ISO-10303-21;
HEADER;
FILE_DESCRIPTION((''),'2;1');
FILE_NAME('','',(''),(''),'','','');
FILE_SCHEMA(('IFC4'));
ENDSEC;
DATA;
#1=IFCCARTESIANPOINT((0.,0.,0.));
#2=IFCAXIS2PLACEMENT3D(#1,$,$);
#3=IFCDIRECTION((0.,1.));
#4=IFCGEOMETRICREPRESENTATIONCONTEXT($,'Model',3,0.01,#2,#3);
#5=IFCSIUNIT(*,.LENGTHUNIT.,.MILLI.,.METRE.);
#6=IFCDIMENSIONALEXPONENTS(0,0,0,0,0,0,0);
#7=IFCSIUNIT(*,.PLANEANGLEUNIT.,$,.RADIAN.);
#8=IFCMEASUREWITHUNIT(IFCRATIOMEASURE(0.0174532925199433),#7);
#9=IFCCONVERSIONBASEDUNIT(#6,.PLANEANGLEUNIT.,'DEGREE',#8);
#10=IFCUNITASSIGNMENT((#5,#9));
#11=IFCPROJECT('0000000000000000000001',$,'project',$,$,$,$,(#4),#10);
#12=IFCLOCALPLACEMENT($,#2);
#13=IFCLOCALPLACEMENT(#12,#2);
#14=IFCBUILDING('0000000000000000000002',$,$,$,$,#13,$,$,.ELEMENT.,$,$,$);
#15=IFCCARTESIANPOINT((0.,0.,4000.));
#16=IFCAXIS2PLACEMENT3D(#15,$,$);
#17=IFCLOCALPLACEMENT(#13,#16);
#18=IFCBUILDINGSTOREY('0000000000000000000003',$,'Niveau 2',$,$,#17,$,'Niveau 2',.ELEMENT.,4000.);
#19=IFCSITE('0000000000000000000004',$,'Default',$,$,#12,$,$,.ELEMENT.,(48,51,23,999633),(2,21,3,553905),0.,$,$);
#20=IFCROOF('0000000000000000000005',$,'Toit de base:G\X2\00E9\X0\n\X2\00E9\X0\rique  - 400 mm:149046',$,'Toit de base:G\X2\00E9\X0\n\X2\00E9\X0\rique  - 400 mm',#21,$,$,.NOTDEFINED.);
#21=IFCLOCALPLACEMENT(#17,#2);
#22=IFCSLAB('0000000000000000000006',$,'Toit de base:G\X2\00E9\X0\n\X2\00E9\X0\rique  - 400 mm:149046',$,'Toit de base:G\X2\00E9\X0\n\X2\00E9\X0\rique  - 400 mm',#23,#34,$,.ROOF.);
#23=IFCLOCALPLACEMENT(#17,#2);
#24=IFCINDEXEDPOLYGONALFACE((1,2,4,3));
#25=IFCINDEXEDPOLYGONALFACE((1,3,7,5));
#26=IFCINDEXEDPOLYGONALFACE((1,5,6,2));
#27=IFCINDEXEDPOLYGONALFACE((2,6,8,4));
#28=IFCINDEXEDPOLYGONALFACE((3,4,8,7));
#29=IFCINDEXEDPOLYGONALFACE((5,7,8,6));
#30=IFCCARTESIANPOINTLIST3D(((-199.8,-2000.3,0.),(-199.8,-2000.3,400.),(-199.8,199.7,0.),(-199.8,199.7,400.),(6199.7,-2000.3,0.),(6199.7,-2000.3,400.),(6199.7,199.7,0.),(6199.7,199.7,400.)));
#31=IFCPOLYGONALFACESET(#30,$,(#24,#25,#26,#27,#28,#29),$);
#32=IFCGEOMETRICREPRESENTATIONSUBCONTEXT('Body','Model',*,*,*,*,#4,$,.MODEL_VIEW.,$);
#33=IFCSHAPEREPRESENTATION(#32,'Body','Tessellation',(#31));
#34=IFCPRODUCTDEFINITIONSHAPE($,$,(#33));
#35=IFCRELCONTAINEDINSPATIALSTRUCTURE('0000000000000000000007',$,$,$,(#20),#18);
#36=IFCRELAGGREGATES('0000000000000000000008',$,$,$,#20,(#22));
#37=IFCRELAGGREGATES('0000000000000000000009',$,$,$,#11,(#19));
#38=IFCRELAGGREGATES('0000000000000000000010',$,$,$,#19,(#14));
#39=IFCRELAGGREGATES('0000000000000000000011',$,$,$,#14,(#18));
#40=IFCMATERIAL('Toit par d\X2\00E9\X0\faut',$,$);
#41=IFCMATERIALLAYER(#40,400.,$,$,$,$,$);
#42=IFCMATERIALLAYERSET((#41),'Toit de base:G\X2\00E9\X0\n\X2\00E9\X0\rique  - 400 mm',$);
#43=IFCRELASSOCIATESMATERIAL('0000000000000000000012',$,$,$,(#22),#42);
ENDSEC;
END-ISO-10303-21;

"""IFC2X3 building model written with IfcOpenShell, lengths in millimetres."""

from ifc_helpers import new_model, entity, si_unit, converted_unit, direction, frame, frame_2d, origin, place, context, subcontext, project, spatial, rectangle, extrude, material, layer, layer_set, element, aggregate, save


model = new_model("IFC2X3")

# Units and contexts
model_context = context("Model", 3, precision=0.01, world=origin(), true_north=direction((0.0, 1.0)))
body_context = subcontext(model_context, "Body", "Model", "MODEL_VIEW")
ifc_project = project(units=[si_unit("LENGTHUNIT", "METRE", prefix="MILLI"), converted_unit("PLANEANGLEUNIT", "DEGREE", entity("IfcRatioMeasure", 0.0174532925199433), si_unit("PLANEANGLEUNIT", "RADIAN"), dimensions=[0, 0, 0, 0, 0, 0, 0])], contexts=[model_context])

# Site, building, storey
site_placement = place(None, origin())
site = spatial("IfcSite", under=ifc_project, at=site_placement, Name="Default", CompositionType="ELEMENT", RefLatitude=(48, 51, 23, 999633), RefLongitude=(2, 21, 3, 553905), RefElevation=0.0)
building_placement = place(site_placement, origin())
building = spatial("IfcBuilding", under=site, at=building_placement, CompositionType="ELEMENT")
storey_placement = place(building_placement, frame((0.0, 0.0, 4000.0)))
storey = spatial("IfcBuildingStorey", under=building, at=storey_placement, Name="Niveau 2", LongName="Niveau 2", CompositionType="ELEMENT", Elevation=4000.0)

# Roof, slab
roof_placement = place(storey_placement, frame((-199.8, -2000.3, 0.0)))
roof = element("IfcRoof", 1, at=roof_placement, inside=storey, Name="Toit de base:Générique  - 400 mm:149046", ObjectType="Toit de base:Générique  - 400 mm", ShapeType="NOTDEFINED")
ifc_material = material(Name="Toit par défaut")
ifc_layer = layer(ifc_material, 400.0)
ifc_layer_set = layer_set([ifc_layer], Name="Toit de base:Générique  - 400 mm")
slab_placement = place(roof_placement, origin())
slab = element("IfcSlab", 2, at=slab_placement, material=ifc_layer_set, Name="Toit de base:Générique  - 400 mm:149046", ObjectType="Toit de base:Générique  - 400 mm", PredefinedType="ROOF", context=body_context, shape_type="SweptSolid", body=[
    extrude(rectangle(XDim=6399.5, YDim=2200.0, at=frame_2d((0.0, 0.0), x_axis=(1.0, 0.0))), frame((3199.8, 1100.0, 0.0)), (0.0, 0.0, 1.0), 400.0),
])
aggregate(roof, [slab])

save(model, "model.ifc")
